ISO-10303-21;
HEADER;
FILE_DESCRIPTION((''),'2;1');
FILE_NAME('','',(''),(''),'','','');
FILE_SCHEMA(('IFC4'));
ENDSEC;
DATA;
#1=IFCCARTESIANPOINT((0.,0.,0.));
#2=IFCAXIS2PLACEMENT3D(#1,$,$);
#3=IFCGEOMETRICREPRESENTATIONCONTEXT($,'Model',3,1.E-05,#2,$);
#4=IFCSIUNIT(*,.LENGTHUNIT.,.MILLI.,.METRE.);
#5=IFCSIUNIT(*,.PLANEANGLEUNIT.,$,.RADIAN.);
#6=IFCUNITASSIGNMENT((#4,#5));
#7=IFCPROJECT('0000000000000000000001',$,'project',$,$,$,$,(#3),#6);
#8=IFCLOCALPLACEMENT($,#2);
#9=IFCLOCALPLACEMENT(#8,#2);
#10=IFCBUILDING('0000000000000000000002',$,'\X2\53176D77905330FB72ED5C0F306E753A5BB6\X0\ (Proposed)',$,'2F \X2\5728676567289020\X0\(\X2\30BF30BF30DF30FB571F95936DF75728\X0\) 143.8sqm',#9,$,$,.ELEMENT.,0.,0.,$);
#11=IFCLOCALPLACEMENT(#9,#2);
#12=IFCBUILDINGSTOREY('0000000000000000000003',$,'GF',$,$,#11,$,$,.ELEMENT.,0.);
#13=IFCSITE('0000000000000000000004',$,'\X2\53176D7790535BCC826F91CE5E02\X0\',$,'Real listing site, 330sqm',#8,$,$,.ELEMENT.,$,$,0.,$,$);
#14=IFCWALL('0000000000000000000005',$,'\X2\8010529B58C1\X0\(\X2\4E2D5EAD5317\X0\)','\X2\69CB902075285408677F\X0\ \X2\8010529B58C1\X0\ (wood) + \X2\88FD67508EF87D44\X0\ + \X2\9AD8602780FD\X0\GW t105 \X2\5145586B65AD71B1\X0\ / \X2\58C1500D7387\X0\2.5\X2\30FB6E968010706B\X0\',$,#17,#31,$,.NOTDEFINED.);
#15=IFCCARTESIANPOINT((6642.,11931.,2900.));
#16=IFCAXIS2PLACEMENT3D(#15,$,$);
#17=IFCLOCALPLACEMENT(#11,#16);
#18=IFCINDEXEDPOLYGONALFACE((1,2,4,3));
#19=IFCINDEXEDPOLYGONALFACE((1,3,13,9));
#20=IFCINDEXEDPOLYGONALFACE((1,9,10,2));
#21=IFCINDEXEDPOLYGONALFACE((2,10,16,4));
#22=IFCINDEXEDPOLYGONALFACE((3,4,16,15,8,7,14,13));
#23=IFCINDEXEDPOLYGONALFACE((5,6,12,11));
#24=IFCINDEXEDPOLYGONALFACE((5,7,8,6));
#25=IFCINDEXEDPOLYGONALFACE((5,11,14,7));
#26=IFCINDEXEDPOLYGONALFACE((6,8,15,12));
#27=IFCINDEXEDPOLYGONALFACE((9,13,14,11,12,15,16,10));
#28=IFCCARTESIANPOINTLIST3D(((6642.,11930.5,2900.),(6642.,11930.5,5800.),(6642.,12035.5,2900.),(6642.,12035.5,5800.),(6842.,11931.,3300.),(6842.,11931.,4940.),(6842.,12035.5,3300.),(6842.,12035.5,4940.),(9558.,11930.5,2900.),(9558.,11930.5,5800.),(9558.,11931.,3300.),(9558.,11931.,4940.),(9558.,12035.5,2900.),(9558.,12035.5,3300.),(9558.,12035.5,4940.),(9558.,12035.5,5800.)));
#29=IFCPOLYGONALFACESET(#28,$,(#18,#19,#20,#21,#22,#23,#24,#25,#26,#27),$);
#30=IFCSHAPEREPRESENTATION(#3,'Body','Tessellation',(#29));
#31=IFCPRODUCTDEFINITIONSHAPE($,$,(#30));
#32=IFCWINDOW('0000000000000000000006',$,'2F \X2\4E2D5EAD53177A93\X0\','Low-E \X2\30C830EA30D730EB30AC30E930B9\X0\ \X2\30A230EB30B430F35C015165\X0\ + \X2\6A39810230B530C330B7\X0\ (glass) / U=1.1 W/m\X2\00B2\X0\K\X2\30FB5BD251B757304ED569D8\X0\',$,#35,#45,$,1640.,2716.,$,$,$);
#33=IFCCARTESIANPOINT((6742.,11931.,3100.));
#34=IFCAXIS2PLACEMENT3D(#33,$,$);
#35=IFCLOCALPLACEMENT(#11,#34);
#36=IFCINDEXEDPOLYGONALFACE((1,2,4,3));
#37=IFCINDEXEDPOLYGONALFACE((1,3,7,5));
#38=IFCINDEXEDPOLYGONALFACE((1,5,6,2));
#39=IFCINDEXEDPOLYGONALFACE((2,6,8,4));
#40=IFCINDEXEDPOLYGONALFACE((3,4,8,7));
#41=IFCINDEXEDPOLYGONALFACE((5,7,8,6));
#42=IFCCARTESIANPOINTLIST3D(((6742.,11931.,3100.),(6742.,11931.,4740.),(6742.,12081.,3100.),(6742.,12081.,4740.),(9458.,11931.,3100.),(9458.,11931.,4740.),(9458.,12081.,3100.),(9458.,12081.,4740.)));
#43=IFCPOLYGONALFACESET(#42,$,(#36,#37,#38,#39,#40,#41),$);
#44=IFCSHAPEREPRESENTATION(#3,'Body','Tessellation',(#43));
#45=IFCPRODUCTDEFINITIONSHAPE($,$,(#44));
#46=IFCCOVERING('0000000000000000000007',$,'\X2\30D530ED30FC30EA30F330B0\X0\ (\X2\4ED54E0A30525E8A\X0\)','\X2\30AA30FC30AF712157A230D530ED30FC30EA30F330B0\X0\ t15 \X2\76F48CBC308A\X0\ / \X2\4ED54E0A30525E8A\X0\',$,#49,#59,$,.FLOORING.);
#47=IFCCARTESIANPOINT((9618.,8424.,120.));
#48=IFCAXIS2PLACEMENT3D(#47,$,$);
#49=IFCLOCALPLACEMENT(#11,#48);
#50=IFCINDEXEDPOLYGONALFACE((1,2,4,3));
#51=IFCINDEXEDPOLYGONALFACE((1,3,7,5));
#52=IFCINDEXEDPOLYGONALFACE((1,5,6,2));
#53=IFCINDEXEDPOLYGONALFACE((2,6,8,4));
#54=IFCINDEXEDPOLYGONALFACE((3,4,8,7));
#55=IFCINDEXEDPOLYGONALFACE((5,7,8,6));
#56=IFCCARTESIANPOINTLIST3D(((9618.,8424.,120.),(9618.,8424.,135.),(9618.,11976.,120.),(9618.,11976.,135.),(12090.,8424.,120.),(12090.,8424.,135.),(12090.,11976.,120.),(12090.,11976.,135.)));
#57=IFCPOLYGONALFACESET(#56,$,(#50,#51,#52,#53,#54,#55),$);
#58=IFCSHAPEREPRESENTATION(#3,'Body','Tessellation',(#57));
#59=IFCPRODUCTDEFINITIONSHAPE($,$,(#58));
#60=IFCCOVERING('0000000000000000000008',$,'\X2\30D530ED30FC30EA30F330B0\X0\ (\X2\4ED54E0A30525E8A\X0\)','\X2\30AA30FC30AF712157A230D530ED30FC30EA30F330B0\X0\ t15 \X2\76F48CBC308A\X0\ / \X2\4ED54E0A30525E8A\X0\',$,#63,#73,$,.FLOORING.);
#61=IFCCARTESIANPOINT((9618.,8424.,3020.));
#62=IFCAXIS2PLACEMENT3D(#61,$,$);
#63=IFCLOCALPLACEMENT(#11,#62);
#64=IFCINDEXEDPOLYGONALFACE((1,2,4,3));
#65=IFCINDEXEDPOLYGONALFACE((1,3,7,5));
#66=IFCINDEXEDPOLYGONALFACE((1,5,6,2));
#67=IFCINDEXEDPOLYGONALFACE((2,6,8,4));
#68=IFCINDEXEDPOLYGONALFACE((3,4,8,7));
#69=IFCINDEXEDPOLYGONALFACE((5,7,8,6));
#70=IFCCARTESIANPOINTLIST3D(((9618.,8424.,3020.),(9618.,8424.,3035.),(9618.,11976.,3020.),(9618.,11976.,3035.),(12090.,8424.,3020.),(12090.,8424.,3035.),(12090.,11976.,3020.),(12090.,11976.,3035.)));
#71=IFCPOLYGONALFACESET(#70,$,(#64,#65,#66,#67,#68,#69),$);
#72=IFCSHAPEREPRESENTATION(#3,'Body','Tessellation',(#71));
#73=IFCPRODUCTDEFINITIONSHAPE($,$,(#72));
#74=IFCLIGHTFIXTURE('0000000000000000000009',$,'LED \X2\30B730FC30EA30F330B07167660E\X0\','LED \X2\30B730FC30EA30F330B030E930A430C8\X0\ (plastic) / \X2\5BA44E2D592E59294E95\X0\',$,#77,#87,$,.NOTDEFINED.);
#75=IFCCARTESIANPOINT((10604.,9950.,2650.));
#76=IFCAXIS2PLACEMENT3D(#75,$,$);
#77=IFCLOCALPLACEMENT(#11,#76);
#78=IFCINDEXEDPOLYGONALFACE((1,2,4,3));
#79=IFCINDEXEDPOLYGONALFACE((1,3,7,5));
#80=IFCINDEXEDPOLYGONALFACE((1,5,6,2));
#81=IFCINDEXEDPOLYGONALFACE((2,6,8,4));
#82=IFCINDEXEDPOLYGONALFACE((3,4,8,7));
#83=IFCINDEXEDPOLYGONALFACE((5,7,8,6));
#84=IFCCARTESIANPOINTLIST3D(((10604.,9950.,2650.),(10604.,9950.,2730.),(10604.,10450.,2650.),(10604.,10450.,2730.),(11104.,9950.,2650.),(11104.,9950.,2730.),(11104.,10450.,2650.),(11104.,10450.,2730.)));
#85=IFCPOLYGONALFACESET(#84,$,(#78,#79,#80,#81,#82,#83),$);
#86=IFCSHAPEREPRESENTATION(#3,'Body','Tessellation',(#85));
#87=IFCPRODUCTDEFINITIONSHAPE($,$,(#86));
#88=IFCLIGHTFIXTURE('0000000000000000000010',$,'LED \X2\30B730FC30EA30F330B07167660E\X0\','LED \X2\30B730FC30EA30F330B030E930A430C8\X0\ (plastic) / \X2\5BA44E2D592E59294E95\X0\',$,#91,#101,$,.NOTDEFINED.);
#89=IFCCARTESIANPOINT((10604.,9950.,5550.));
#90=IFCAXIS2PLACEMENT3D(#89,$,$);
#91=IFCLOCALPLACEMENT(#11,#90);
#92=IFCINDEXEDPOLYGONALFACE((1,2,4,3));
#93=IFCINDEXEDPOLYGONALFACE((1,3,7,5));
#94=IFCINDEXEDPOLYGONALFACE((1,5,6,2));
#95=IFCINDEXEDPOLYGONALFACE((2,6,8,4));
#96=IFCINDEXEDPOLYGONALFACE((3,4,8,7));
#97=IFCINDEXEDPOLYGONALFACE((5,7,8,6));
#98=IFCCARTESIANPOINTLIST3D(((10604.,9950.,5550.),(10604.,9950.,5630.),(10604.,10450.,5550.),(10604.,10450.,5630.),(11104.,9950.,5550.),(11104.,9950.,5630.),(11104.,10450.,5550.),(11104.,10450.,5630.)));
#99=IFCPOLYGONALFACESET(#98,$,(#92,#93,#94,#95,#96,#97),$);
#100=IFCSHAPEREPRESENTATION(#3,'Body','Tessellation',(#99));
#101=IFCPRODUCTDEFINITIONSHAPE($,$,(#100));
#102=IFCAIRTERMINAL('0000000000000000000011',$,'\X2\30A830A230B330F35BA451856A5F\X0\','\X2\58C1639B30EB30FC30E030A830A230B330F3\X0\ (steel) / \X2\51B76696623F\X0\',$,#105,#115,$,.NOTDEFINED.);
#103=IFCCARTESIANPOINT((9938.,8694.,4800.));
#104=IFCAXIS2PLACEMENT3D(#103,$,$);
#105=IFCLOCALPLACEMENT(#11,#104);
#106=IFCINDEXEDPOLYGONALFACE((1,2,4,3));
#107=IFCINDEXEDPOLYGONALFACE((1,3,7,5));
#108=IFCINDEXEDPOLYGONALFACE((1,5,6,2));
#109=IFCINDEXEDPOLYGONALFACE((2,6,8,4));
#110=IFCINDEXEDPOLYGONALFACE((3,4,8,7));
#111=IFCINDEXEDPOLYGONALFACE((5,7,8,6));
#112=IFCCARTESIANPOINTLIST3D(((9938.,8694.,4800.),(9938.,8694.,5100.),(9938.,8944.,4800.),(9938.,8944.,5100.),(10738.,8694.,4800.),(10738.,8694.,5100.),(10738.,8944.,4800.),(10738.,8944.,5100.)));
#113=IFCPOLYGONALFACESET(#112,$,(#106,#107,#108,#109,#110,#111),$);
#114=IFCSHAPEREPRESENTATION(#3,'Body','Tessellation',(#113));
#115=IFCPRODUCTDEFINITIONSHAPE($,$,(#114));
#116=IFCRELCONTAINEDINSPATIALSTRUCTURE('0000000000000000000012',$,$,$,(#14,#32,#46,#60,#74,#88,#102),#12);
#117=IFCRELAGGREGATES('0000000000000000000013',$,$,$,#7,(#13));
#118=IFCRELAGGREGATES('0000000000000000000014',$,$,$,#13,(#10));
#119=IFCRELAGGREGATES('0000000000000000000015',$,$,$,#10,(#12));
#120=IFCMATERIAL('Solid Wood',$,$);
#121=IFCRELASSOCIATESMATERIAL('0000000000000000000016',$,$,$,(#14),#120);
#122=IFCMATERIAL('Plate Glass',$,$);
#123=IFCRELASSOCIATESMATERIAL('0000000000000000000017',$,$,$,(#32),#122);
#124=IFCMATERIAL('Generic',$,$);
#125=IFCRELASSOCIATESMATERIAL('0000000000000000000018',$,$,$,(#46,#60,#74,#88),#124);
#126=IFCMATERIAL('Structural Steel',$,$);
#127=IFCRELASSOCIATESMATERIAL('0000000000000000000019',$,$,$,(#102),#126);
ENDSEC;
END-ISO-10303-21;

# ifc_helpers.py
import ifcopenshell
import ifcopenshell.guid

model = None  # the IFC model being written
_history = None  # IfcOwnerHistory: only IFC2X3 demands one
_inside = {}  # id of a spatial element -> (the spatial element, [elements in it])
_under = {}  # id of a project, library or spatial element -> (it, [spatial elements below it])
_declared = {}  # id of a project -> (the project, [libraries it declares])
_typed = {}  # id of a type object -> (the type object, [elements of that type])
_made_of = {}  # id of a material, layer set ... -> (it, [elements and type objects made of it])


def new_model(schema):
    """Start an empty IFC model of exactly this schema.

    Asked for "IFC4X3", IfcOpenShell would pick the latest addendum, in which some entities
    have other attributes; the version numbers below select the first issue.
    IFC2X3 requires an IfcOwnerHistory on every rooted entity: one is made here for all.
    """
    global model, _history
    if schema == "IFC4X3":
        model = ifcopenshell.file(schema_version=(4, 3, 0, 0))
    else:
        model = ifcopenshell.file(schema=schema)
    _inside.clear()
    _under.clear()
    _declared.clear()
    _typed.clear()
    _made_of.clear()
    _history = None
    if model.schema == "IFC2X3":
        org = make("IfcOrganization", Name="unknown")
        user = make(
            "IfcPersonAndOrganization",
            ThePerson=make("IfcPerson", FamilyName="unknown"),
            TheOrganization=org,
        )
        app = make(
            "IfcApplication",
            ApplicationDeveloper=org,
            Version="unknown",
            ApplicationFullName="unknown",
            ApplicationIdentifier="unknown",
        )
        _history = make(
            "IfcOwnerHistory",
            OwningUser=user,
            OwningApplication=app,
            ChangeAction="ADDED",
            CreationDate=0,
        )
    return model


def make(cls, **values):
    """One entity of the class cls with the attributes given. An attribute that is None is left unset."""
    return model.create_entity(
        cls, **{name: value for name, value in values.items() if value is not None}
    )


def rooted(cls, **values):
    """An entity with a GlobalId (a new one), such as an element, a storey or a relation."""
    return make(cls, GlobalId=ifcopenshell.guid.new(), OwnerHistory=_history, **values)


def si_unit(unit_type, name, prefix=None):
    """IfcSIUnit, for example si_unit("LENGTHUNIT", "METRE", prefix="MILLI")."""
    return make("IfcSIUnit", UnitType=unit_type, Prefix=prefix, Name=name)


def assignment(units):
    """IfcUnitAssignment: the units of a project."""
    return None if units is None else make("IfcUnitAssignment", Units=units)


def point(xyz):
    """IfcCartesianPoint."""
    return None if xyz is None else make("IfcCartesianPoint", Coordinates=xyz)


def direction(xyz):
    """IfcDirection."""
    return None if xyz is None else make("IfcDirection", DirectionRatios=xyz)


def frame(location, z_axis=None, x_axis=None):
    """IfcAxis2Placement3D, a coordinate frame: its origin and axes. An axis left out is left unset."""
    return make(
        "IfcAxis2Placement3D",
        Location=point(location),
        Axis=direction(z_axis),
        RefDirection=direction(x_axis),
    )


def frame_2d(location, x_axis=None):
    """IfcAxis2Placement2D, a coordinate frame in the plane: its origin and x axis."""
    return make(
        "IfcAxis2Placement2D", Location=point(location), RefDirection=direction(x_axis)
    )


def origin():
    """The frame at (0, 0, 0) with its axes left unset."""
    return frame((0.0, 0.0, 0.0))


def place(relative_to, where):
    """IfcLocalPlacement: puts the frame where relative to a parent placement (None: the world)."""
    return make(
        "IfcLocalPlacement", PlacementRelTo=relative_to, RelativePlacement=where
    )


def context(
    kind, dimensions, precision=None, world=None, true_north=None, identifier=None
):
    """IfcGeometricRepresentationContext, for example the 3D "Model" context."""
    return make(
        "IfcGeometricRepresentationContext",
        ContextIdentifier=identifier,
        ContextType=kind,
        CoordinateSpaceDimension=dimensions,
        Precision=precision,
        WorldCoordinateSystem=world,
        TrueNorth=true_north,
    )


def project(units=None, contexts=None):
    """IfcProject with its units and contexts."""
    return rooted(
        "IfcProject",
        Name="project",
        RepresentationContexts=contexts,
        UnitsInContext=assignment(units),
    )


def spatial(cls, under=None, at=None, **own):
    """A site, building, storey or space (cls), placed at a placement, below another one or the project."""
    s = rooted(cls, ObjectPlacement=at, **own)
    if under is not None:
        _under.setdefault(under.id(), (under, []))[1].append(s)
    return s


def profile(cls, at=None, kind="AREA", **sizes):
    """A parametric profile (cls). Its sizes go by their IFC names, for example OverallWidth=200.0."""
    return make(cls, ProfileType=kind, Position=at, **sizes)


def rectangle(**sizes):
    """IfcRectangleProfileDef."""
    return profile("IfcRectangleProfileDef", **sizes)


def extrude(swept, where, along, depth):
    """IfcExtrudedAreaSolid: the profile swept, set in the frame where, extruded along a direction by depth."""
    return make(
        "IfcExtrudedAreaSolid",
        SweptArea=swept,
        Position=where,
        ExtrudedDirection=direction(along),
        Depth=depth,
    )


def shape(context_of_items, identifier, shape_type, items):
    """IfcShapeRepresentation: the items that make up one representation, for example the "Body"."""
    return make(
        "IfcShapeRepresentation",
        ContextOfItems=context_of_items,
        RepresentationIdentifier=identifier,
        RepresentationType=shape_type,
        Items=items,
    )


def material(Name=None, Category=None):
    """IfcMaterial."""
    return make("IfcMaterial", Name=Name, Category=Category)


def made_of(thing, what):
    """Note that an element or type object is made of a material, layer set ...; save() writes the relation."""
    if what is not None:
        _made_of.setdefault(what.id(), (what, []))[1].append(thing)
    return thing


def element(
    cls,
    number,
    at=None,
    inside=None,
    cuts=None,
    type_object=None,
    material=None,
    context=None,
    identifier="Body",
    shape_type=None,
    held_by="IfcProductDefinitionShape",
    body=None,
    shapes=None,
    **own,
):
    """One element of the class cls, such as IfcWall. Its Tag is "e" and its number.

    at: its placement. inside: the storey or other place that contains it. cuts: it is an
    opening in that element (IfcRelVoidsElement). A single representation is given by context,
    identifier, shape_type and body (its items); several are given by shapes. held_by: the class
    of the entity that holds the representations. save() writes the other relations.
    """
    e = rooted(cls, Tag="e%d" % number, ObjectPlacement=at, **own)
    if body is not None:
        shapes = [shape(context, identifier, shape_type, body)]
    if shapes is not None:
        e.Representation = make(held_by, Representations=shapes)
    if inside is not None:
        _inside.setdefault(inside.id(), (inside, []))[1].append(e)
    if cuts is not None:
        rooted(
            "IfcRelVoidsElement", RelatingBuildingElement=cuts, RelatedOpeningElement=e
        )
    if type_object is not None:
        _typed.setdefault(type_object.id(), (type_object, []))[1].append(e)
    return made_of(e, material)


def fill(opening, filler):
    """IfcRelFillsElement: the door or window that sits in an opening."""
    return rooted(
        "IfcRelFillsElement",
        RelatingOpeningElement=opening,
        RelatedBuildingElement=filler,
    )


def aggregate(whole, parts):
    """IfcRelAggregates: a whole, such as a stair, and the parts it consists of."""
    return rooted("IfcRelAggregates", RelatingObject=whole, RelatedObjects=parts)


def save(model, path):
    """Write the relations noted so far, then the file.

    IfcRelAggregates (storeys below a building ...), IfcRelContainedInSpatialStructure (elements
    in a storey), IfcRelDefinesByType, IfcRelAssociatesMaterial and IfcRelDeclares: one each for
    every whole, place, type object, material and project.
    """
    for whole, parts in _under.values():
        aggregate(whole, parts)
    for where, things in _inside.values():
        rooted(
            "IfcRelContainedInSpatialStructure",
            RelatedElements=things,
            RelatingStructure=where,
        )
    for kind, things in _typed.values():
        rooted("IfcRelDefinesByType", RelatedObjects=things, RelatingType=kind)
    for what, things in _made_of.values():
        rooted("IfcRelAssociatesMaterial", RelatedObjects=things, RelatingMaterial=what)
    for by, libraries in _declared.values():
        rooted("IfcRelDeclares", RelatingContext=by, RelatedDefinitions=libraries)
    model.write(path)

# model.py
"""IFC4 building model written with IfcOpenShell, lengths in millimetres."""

from ifc_helpers import new_model, si_unit, frame, frame_2d, origin, place, context, project, spatial, rectangle, extrude, material, element, fill, save


model = new_model("IFC4")

# Units and contexts
model_context = context("Model", 3, precision=1e-05, world=origin())
ifc_project = project(units=[si_unit("LENGTHUNIT", "METRE", prefix="MILLI"), si_unit("PLANEANGLEUNIT", "RADIAN")], contexts=[model_context])

# Site, building, storey
site_placement = place(None, origin())
site = spatial("IfcSite", under=ifc_project, at=site_placement, Name="北海道富良野市", ObjectType="Real listing site, 330sqm", CompositionType="ELEMENT", RefElevation=0.0)
building_placement = place(site_placement, origin())
building = spatial("IfcBuilding", under=site, at=building_placement, Name="北海道・狭小の町家 (Proposed)", ObjectType="2F 在来木造(タタミ・土間混在) 143.8sqm", CompositionType="ELEMENT", ElevationOfRefHeight=0.0, ElevationOfTerrain=0.0)
storey_placement = place(building_placement, origin())
storey = spatial("IfcBuildingStorey", under=building, at=storey_placement, Name="GF", CompositionType="ELEMENT", Elevation=0.0)

# Shared definitions
ifc_material_1 = material(Name="Solid Wood")

# Wall, opening, window
ifc_material_2 = material(Name="Plate Glass")
wall_1_placement = place(storey_placement, frame((6642.0, 11931.0, 2900.0)))
wall_1 = element("IfcWall", 1, at=wall_1_placement, inside=storey, material=ifc_material_1, Name="耐力壁(中庭北)", Description="構造用合板 耐力壁 (wood) + 製材軸組 + 高性能GW t105 充填断熱 / 壁倍率2.5・準耐火", PredefinedType="NOTDEFINED", context=model_context, shape_type="SweptSolid", body=[
    extrude(rectangle(XDim=2916.0, YDim=105.0, at=frame_2d((1458.0, 52.0))), frame((6642.0, 11931.0, 2900.0)), (0.0, 0.0, 1.0), 2900.0),
])
opening_1_placement = place(storey_placement, frame((6742.0, 11931.0, 3100.0)))
opening_1 = element("IfcOpeningElement", 2, at=opening_1_placement, cuts=wall_1, PredefinedType="NOTDEFINED", context=model_context, shape_type="SweptSolid", body=[
    extrude(rectangle(XDim=2716.0, YDim=150.0, at=frame_2d((1358.0, 75.0))), frame((6742.0, 11931.0, 3100.0)), (0.0, 0.0, 1.0), 1640.0),
])
window_1_placement = place(storey_placement, frame((6742.0, 11931.0, 3100.0)))
window_1 = element("IfcWindow", 3, at=window_1_placement, inside=storey, material=ifc_material_2, Name="2F 中庭北窓", Description="Low-E トリプルガラス アルゴン封入 + 樹脂サッシ (glass) / U=1.1 W/m²K・寒冷地仕様", OverallHeight=1640.0, OverallWidth=2716.0, context=model_context, shape_type="SweptSolid", body=[
    extrude(rectangle(XDim=2716.0, YDim=150.0, at=frame_2d((1358.0, 75.0))), frame((6742.0, 11931.0, 3100.0)), (0.0, 0.0, 1.0), 1640.0),
])
fill(opening_1, window_1)

# Coverings
ifc_material_3 = material(Name="Generic")
covering_1_placement = place(storey_placement, frame((9618.0, 8424.0, 120.0)))
element("IfcCovering", 4, at=covering_1_placement, inside=storey, material=ifc_material_3, Name="フローリング (仕上げ床)", Description="オーク無垢フローリング t15 直貼り / 仕上げ床", PredefinedType="FLOORING", context=model_context, shape_type="SweptSolid", body=[
    extrude(rectangle(XDim=2472.0, YDim=3552.0, at=frame_2d((1236.0, 1776.0))), frame((9618.0, 8424.0, 120.0)), (0.0, 0.0, 1.0), 15.0),
])
covering_2_placement = place(storey_placement, frame((9618.0, 8424.0, 3020.0)))
element("IfcCovering", 5, at=covering_2_placement, inside=storey, material=ifc_material_3, Name="フローリング (仕上げ床)", Description="オーク無垢フローリング t15 直貼り / 仕上げ床", PredefinedType="FLOORING", context=model_context, shape_type="SweptSolid", body=[
    extrude(rectangle(XDim=2472.0, YDim=3552.0, at=frame_2d((1236.0, 1776.0))), frame((9618.0, 8424.0, 3020.0)), (0.0, 0.0, 1.0), 15.0),
])

# Light fixtures
light_fixture_1_placement = place(storey_placement, frame((10604.0, 9950.0, 2650.0)))
element("IfcLightFixture", 6, at=light_fixture_1_placement, inside=storey, material=ifc_material_3, Name="LED シーリング照明", Description="LED シーリングライト (plastic) / 室中央天井", PredefinedType="NOTDEFINED", context=model_context, shape_type="SweptSolid", body=[
    extrude(rectangle(XDim=500.0, YDim=500.0, at=frame_2d((250.0, 250.0))), frame((10604.0, 9950.0, 2650.0)), (0.0, 0.0, 1.0), 80.0),
])
light_fixture_2_placement = place(storey_placement, frame((10604.0, 9950.0, 5550.0)))
element("IfcLightFixture", 7, at=light_fixture_2_placement, inside=storey, material=ifc_material_3, Name="LED シーリング照明", Description="LED シーリングライト (plastic) / 室中央天井", PredefinedType="NOTDEFINED", context=model_context, shape_type="SweptSolid", body=[
    extrude(rectangle(XDim=500.0, YDim=500.0, at=frame_2d((250.0, 250.0))), frame((10604.0, 9950.0, 5550.0)), (0.0, 0.0, 1.0), 80.0),
])

# Air terminal
ifc_material_4 = material(Name="Structural Steel")
air_terminal_placement = place(storey_placement, frame((9938.0, 8694.0, 4800.0)))
element("IfcAirTerminal", 8, at=air_terminal_placement, inside=storey, material=ifc_material_4, Name="エアコン室内機", Description="壁掛ルームエアコン (steel) / 冷暖房", PredefinedType="NOTDEFINED", context=model_context, shape_type="SweptSolid", body=[
    extrude(rectangle(XDim=800.0, YDim=250.0, at=frame_2d((400.0, 125.0))), frame((9938.0, 8694.0, 4800.0)), (0.0, 0.0, 1.0), 300.0),
])

save(model, "model.ifc")
